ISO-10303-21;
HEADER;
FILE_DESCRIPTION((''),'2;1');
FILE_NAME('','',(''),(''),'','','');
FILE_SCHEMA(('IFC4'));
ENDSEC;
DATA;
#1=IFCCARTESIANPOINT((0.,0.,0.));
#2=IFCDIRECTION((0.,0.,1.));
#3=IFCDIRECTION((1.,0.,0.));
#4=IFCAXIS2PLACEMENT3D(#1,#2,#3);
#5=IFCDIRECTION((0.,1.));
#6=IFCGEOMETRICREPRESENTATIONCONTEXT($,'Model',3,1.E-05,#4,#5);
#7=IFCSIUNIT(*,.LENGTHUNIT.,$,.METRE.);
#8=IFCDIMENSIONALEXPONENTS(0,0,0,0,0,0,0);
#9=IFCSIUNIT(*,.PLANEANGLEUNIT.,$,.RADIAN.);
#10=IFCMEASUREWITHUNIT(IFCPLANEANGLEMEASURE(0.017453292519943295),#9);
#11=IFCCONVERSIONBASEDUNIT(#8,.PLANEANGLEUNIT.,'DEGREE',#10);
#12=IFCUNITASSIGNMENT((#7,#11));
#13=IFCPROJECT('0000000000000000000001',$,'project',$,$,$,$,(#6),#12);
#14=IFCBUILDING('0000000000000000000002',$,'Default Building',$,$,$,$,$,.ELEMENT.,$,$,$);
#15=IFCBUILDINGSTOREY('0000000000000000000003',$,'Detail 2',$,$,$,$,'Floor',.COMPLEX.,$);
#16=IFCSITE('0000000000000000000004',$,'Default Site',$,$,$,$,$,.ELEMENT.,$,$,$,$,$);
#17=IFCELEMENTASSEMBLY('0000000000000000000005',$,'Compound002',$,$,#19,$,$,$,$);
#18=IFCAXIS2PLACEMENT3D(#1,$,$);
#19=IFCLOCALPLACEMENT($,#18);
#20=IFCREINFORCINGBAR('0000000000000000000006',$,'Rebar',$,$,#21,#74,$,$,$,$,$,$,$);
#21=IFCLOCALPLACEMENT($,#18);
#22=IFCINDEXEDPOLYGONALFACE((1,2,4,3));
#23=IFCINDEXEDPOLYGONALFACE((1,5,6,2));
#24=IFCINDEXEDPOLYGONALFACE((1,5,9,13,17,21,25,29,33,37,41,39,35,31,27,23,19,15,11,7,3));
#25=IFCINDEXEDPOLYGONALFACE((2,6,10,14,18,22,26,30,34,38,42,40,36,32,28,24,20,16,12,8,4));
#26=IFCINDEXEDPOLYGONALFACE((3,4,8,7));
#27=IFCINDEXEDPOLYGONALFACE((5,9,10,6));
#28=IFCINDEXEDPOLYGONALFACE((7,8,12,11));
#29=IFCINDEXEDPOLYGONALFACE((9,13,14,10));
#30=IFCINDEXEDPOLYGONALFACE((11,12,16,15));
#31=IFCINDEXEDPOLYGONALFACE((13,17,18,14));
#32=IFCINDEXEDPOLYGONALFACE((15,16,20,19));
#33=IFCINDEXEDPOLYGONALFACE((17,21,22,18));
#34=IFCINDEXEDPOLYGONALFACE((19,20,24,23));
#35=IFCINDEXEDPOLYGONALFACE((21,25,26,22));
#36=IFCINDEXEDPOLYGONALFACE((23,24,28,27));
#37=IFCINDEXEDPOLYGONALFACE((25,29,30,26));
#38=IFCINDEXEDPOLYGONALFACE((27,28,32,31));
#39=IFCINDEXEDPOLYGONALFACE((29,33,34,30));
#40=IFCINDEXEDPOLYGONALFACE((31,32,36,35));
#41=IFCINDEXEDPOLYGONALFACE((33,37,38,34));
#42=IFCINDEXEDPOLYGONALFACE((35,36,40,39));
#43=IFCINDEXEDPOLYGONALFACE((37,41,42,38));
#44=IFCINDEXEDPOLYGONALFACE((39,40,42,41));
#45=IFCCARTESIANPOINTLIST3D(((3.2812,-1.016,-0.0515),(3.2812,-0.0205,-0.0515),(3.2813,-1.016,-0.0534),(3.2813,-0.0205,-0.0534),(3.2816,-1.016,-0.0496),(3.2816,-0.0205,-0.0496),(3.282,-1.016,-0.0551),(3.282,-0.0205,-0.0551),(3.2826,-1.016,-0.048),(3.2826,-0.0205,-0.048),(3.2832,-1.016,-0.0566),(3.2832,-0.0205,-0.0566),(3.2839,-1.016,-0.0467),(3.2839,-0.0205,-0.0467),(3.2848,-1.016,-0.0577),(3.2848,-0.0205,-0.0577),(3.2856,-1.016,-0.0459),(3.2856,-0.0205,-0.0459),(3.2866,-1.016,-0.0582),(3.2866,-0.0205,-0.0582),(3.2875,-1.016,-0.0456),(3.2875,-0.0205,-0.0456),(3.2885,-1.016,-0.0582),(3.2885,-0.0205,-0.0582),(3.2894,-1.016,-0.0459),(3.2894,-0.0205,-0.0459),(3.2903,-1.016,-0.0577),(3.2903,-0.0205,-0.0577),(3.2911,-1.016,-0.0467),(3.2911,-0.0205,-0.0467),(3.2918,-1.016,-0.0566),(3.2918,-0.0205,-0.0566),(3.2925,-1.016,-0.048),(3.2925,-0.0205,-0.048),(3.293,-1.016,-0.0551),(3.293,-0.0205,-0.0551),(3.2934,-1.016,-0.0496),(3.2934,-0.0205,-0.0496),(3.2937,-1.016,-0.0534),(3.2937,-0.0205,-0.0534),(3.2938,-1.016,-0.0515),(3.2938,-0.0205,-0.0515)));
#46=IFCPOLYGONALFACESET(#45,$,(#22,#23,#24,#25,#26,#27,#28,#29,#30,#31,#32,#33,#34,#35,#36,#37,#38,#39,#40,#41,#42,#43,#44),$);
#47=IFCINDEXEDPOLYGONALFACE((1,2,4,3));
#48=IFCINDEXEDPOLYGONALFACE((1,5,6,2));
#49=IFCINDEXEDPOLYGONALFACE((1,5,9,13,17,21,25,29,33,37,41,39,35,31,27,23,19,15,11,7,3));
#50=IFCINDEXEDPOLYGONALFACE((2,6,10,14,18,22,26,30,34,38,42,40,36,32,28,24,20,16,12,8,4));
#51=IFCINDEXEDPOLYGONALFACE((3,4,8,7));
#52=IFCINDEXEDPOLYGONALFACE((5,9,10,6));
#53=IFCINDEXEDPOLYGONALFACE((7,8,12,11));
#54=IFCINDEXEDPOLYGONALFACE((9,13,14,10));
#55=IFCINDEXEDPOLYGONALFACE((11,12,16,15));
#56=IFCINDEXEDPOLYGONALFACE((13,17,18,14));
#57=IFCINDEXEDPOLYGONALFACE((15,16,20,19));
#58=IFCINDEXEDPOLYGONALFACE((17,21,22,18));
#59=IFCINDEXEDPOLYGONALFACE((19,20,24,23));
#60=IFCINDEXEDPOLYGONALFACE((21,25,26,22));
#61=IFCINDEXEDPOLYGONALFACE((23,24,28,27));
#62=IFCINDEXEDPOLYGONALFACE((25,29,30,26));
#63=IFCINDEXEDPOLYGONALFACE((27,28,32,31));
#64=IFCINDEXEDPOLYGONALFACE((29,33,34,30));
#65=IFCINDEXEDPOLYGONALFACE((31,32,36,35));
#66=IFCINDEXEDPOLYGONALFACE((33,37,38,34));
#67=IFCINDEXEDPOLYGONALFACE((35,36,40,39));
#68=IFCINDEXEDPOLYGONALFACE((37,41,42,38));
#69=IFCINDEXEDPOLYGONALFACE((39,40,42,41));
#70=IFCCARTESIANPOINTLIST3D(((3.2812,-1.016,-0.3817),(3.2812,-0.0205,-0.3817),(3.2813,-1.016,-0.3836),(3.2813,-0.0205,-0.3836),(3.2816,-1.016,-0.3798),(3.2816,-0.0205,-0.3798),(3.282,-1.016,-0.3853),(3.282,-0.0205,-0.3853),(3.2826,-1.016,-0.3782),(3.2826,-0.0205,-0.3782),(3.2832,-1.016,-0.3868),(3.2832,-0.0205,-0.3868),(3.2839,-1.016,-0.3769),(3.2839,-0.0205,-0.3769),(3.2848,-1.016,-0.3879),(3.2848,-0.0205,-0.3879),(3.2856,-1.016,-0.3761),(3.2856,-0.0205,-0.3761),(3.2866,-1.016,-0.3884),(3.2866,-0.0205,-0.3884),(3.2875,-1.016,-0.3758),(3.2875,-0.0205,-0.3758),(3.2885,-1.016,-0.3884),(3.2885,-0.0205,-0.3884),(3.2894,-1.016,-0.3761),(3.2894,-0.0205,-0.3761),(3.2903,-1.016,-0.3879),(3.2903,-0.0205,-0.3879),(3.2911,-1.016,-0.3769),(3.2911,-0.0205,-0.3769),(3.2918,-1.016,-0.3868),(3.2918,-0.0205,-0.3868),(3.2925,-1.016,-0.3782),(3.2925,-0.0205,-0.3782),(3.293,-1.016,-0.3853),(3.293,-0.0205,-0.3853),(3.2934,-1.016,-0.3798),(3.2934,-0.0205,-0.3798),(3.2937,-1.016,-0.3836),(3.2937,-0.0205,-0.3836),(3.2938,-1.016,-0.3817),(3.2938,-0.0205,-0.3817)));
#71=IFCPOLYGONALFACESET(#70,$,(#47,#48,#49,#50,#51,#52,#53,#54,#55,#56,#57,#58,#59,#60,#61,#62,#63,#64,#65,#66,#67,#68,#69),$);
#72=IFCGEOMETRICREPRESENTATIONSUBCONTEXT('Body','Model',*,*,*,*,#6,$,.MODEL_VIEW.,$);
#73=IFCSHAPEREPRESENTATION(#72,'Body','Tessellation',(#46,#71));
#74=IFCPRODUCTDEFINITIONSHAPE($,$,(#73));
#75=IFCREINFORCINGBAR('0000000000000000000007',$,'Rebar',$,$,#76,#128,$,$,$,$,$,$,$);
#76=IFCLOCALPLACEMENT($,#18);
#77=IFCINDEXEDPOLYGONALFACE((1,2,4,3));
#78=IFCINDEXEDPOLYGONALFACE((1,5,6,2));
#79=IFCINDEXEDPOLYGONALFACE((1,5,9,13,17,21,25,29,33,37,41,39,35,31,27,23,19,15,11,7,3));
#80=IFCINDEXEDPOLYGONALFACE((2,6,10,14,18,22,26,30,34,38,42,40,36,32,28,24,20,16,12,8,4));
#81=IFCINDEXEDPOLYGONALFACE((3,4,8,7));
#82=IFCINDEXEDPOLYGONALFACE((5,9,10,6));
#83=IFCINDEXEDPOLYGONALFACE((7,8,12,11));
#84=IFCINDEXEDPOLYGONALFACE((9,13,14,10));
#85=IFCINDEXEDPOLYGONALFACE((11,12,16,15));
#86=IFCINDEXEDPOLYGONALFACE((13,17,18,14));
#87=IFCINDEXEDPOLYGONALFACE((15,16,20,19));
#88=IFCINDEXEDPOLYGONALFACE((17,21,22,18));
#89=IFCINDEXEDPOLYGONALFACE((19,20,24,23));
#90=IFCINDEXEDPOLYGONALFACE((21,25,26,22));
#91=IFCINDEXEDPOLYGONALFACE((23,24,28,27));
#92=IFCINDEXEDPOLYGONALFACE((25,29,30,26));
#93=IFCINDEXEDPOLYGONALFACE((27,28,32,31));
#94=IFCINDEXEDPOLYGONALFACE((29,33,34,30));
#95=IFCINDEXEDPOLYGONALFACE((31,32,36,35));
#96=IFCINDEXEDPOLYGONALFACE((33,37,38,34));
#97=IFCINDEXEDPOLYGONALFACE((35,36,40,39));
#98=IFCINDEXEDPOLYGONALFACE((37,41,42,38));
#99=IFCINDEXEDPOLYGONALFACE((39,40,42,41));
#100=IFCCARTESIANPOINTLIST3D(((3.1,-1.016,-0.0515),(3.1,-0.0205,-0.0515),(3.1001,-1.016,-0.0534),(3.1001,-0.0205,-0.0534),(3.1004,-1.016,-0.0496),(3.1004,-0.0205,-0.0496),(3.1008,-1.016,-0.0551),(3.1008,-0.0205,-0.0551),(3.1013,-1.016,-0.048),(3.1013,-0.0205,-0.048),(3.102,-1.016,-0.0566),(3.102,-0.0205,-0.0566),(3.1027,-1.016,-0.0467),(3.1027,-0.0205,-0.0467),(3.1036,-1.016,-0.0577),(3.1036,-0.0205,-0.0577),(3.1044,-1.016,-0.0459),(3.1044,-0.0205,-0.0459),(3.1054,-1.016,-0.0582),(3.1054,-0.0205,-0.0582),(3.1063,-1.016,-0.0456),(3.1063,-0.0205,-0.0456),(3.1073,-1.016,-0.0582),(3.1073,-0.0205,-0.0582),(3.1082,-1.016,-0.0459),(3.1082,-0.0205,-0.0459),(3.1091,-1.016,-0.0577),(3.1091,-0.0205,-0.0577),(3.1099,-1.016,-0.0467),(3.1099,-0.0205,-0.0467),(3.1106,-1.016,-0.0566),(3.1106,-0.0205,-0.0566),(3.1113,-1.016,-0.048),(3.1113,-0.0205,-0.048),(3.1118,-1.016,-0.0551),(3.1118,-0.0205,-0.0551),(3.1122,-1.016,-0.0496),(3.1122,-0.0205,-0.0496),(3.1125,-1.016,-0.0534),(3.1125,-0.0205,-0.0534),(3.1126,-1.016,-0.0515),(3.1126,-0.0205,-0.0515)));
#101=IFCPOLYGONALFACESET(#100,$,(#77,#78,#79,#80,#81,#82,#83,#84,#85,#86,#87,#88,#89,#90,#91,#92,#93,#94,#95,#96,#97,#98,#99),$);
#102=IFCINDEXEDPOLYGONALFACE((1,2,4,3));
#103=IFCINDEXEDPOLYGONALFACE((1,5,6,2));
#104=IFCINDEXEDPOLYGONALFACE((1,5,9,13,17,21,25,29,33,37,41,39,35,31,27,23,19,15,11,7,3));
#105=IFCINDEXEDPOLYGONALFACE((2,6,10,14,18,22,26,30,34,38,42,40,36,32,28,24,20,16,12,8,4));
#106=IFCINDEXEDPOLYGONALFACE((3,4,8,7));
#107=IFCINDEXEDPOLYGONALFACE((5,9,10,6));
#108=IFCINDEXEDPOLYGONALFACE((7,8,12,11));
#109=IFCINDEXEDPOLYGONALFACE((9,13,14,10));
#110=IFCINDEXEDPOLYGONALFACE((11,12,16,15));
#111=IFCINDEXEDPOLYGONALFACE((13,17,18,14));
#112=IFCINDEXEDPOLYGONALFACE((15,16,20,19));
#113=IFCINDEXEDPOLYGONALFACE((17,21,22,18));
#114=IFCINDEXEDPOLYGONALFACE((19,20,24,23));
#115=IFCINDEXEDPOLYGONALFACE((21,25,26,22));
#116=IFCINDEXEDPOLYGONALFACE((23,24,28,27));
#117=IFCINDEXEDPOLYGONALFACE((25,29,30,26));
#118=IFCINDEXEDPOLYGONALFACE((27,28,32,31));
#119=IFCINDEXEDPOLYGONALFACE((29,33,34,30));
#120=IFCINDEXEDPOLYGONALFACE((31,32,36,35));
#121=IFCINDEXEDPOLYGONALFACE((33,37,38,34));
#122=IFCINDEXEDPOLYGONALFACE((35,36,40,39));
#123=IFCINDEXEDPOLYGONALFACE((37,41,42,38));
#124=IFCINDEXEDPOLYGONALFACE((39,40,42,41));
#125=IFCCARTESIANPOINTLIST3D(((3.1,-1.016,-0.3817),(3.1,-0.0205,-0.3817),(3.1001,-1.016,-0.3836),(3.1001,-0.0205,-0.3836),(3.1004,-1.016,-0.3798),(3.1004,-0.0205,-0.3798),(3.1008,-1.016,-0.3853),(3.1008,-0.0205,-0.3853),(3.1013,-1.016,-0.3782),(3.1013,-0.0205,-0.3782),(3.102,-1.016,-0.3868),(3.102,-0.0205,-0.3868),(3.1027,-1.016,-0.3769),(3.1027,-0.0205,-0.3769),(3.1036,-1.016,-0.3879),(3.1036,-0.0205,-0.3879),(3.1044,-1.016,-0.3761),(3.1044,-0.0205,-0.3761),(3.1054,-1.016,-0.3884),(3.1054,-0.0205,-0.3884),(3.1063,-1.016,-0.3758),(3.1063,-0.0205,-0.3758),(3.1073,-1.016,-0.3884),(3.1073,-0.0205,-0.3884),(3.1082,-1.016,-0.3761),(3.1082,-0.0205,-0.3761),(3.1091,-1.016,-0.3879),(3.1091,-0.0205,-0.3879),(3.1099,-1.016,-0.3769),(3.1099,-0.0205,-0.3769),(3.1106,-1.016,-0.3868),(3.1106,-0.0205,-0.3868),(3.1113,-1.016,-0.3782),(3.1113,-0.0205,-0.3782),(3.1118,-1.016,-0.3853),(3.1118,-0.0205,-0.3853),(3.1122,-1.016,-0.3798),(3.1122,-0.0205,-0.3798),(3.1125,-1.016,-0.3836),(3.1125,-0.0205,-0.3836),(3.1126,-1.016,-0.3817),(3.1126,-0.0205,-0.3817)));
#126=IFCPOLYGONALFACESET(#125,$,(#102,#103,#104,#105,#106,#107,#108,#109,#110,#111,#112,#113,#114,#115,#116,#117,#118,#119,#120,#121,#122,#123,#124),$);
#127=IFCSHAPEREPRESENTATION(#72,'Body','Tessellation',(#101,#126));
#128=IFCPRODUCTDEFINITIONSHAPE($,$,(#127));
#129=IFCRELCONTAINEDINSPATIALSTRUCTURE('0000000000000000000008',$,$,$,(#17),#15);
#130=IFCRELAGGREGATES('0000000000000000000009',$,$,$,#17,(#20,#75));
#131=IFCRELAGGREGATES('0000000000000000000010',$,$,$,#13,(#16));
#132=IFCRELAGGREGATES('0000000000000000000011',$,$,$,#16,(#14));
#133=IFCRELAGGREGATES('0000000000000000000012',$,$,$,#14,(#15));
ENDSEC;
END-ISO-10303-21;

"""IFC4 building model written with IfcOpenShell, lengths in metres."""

from ifc_helpers import new_model, entity, si_unit, converted_unit, direction, origin_with_axes, place, context, subcontext, project, spatial, element, aggregate, save


model = new_model("IFC4")

# Units and contexts
model_context = context("Model", 3, precision=1e-05, world=origin_with_axes(), true_north=direction((0.0, 1.0)))
body_context = subcontext(model_context, "Body", "Model", "MODEL_VIEW")
ifc_project = project(units=[si_unit("LENGTHUNIT", "METRE"), converted_unit("PLANEANGLEUNIT", "DEGREE", entity("IfcPlaneAngleMeasure", 0.017453292519943295), si_unit("PLANEANGLEUNIT", "RADIAN"), dimensions=[0, 0, 0, 0, 0, 0, 0])], contexts=[model_context])

# Site, building, storey
site = spatial("IfcSite", under=ifc_project, Name="Default Site", CompositionType="ELEMENT")
building = spatial("IfcBuilding", under=site, Name="Default Building", CompositionType="ELEMENT")
storey = spatial("IfcBuildingStorey", under=building, Name="Detail 2", LongName="Floor", CompositionType="COMPLEX")

# Shared definitions
placement = place(None, origin_with_axes())

# Element assembly, reinforcing bars
assembly_1 = element("IfcElementAssembly", 1, inside=storey, Name="Compound002")
reinforcing_bar_1 = element("IfcReinforcingBar", 2, at=placement, Name="Rebar", context=body_context, shape_type="SweptSolid", body=[
    entity("IfcSweptDiskSolid", entity("IfcCompositeCurve", [entity("IfcCompositeCurveSegment", "CONTINUOUS", True, entity("IfcPolyline", [entity("IfcCartesianPoint", [3.2875, -1.016, -0.052]), entity("IfcCartesianPoint", [3.2875, -0.0205, -0.052])]))], False), 0.0063),
    entity("IfcSweptDiskSolid", entity("IfcCompositeCurve", [entity("IfcCompositeCurveSegment", "CONTINUOUS", True, entity("IfcPolyline", [entity("IfcCartesianPoint", [3.2875, -1.016, -0.3822]), entity("IfcCartesianPoint", [3.2875, -0.0205, -0.3822])]))], False), 0.0063),
])
reinforcing_bar_2 = element("IfcReinforcingBar", 3, at=placement, Name="Rebar", context=body_context, shape_type="SweptSolid", body=[
    entity("IfcSweptDiskSolid", entity("IfcCompositeCurve", [entity("IfcCompositeCurveSegment", "CONTINUOUS", True, entity("IfcPolyline", [entity("IfcCartesianPoint", [3.1063, -1.016, -0.052]), entity("IfcCartesianPoint", [3.1063, -0.0205, -0.052])]))], False), 0.0063),
    entity("IfcSweptDiskSolid", entity("IfcCompositeCurve", [entity("IfcCompositeCurveSegment", "CONTINUOUS", True, entity("IfcPolyline", [entity("IfcCartesianPoint", [3.1063, -1.016, -0.3822]), entity("IfcCartesianPoint", [3.1063, -0.0205, -0.3822])]))], False), 0.0063),
])
aggregate(assembly_1, [reinforcing_bar_1, reinforcing_bar_2])

save(model, "model.ifc")
